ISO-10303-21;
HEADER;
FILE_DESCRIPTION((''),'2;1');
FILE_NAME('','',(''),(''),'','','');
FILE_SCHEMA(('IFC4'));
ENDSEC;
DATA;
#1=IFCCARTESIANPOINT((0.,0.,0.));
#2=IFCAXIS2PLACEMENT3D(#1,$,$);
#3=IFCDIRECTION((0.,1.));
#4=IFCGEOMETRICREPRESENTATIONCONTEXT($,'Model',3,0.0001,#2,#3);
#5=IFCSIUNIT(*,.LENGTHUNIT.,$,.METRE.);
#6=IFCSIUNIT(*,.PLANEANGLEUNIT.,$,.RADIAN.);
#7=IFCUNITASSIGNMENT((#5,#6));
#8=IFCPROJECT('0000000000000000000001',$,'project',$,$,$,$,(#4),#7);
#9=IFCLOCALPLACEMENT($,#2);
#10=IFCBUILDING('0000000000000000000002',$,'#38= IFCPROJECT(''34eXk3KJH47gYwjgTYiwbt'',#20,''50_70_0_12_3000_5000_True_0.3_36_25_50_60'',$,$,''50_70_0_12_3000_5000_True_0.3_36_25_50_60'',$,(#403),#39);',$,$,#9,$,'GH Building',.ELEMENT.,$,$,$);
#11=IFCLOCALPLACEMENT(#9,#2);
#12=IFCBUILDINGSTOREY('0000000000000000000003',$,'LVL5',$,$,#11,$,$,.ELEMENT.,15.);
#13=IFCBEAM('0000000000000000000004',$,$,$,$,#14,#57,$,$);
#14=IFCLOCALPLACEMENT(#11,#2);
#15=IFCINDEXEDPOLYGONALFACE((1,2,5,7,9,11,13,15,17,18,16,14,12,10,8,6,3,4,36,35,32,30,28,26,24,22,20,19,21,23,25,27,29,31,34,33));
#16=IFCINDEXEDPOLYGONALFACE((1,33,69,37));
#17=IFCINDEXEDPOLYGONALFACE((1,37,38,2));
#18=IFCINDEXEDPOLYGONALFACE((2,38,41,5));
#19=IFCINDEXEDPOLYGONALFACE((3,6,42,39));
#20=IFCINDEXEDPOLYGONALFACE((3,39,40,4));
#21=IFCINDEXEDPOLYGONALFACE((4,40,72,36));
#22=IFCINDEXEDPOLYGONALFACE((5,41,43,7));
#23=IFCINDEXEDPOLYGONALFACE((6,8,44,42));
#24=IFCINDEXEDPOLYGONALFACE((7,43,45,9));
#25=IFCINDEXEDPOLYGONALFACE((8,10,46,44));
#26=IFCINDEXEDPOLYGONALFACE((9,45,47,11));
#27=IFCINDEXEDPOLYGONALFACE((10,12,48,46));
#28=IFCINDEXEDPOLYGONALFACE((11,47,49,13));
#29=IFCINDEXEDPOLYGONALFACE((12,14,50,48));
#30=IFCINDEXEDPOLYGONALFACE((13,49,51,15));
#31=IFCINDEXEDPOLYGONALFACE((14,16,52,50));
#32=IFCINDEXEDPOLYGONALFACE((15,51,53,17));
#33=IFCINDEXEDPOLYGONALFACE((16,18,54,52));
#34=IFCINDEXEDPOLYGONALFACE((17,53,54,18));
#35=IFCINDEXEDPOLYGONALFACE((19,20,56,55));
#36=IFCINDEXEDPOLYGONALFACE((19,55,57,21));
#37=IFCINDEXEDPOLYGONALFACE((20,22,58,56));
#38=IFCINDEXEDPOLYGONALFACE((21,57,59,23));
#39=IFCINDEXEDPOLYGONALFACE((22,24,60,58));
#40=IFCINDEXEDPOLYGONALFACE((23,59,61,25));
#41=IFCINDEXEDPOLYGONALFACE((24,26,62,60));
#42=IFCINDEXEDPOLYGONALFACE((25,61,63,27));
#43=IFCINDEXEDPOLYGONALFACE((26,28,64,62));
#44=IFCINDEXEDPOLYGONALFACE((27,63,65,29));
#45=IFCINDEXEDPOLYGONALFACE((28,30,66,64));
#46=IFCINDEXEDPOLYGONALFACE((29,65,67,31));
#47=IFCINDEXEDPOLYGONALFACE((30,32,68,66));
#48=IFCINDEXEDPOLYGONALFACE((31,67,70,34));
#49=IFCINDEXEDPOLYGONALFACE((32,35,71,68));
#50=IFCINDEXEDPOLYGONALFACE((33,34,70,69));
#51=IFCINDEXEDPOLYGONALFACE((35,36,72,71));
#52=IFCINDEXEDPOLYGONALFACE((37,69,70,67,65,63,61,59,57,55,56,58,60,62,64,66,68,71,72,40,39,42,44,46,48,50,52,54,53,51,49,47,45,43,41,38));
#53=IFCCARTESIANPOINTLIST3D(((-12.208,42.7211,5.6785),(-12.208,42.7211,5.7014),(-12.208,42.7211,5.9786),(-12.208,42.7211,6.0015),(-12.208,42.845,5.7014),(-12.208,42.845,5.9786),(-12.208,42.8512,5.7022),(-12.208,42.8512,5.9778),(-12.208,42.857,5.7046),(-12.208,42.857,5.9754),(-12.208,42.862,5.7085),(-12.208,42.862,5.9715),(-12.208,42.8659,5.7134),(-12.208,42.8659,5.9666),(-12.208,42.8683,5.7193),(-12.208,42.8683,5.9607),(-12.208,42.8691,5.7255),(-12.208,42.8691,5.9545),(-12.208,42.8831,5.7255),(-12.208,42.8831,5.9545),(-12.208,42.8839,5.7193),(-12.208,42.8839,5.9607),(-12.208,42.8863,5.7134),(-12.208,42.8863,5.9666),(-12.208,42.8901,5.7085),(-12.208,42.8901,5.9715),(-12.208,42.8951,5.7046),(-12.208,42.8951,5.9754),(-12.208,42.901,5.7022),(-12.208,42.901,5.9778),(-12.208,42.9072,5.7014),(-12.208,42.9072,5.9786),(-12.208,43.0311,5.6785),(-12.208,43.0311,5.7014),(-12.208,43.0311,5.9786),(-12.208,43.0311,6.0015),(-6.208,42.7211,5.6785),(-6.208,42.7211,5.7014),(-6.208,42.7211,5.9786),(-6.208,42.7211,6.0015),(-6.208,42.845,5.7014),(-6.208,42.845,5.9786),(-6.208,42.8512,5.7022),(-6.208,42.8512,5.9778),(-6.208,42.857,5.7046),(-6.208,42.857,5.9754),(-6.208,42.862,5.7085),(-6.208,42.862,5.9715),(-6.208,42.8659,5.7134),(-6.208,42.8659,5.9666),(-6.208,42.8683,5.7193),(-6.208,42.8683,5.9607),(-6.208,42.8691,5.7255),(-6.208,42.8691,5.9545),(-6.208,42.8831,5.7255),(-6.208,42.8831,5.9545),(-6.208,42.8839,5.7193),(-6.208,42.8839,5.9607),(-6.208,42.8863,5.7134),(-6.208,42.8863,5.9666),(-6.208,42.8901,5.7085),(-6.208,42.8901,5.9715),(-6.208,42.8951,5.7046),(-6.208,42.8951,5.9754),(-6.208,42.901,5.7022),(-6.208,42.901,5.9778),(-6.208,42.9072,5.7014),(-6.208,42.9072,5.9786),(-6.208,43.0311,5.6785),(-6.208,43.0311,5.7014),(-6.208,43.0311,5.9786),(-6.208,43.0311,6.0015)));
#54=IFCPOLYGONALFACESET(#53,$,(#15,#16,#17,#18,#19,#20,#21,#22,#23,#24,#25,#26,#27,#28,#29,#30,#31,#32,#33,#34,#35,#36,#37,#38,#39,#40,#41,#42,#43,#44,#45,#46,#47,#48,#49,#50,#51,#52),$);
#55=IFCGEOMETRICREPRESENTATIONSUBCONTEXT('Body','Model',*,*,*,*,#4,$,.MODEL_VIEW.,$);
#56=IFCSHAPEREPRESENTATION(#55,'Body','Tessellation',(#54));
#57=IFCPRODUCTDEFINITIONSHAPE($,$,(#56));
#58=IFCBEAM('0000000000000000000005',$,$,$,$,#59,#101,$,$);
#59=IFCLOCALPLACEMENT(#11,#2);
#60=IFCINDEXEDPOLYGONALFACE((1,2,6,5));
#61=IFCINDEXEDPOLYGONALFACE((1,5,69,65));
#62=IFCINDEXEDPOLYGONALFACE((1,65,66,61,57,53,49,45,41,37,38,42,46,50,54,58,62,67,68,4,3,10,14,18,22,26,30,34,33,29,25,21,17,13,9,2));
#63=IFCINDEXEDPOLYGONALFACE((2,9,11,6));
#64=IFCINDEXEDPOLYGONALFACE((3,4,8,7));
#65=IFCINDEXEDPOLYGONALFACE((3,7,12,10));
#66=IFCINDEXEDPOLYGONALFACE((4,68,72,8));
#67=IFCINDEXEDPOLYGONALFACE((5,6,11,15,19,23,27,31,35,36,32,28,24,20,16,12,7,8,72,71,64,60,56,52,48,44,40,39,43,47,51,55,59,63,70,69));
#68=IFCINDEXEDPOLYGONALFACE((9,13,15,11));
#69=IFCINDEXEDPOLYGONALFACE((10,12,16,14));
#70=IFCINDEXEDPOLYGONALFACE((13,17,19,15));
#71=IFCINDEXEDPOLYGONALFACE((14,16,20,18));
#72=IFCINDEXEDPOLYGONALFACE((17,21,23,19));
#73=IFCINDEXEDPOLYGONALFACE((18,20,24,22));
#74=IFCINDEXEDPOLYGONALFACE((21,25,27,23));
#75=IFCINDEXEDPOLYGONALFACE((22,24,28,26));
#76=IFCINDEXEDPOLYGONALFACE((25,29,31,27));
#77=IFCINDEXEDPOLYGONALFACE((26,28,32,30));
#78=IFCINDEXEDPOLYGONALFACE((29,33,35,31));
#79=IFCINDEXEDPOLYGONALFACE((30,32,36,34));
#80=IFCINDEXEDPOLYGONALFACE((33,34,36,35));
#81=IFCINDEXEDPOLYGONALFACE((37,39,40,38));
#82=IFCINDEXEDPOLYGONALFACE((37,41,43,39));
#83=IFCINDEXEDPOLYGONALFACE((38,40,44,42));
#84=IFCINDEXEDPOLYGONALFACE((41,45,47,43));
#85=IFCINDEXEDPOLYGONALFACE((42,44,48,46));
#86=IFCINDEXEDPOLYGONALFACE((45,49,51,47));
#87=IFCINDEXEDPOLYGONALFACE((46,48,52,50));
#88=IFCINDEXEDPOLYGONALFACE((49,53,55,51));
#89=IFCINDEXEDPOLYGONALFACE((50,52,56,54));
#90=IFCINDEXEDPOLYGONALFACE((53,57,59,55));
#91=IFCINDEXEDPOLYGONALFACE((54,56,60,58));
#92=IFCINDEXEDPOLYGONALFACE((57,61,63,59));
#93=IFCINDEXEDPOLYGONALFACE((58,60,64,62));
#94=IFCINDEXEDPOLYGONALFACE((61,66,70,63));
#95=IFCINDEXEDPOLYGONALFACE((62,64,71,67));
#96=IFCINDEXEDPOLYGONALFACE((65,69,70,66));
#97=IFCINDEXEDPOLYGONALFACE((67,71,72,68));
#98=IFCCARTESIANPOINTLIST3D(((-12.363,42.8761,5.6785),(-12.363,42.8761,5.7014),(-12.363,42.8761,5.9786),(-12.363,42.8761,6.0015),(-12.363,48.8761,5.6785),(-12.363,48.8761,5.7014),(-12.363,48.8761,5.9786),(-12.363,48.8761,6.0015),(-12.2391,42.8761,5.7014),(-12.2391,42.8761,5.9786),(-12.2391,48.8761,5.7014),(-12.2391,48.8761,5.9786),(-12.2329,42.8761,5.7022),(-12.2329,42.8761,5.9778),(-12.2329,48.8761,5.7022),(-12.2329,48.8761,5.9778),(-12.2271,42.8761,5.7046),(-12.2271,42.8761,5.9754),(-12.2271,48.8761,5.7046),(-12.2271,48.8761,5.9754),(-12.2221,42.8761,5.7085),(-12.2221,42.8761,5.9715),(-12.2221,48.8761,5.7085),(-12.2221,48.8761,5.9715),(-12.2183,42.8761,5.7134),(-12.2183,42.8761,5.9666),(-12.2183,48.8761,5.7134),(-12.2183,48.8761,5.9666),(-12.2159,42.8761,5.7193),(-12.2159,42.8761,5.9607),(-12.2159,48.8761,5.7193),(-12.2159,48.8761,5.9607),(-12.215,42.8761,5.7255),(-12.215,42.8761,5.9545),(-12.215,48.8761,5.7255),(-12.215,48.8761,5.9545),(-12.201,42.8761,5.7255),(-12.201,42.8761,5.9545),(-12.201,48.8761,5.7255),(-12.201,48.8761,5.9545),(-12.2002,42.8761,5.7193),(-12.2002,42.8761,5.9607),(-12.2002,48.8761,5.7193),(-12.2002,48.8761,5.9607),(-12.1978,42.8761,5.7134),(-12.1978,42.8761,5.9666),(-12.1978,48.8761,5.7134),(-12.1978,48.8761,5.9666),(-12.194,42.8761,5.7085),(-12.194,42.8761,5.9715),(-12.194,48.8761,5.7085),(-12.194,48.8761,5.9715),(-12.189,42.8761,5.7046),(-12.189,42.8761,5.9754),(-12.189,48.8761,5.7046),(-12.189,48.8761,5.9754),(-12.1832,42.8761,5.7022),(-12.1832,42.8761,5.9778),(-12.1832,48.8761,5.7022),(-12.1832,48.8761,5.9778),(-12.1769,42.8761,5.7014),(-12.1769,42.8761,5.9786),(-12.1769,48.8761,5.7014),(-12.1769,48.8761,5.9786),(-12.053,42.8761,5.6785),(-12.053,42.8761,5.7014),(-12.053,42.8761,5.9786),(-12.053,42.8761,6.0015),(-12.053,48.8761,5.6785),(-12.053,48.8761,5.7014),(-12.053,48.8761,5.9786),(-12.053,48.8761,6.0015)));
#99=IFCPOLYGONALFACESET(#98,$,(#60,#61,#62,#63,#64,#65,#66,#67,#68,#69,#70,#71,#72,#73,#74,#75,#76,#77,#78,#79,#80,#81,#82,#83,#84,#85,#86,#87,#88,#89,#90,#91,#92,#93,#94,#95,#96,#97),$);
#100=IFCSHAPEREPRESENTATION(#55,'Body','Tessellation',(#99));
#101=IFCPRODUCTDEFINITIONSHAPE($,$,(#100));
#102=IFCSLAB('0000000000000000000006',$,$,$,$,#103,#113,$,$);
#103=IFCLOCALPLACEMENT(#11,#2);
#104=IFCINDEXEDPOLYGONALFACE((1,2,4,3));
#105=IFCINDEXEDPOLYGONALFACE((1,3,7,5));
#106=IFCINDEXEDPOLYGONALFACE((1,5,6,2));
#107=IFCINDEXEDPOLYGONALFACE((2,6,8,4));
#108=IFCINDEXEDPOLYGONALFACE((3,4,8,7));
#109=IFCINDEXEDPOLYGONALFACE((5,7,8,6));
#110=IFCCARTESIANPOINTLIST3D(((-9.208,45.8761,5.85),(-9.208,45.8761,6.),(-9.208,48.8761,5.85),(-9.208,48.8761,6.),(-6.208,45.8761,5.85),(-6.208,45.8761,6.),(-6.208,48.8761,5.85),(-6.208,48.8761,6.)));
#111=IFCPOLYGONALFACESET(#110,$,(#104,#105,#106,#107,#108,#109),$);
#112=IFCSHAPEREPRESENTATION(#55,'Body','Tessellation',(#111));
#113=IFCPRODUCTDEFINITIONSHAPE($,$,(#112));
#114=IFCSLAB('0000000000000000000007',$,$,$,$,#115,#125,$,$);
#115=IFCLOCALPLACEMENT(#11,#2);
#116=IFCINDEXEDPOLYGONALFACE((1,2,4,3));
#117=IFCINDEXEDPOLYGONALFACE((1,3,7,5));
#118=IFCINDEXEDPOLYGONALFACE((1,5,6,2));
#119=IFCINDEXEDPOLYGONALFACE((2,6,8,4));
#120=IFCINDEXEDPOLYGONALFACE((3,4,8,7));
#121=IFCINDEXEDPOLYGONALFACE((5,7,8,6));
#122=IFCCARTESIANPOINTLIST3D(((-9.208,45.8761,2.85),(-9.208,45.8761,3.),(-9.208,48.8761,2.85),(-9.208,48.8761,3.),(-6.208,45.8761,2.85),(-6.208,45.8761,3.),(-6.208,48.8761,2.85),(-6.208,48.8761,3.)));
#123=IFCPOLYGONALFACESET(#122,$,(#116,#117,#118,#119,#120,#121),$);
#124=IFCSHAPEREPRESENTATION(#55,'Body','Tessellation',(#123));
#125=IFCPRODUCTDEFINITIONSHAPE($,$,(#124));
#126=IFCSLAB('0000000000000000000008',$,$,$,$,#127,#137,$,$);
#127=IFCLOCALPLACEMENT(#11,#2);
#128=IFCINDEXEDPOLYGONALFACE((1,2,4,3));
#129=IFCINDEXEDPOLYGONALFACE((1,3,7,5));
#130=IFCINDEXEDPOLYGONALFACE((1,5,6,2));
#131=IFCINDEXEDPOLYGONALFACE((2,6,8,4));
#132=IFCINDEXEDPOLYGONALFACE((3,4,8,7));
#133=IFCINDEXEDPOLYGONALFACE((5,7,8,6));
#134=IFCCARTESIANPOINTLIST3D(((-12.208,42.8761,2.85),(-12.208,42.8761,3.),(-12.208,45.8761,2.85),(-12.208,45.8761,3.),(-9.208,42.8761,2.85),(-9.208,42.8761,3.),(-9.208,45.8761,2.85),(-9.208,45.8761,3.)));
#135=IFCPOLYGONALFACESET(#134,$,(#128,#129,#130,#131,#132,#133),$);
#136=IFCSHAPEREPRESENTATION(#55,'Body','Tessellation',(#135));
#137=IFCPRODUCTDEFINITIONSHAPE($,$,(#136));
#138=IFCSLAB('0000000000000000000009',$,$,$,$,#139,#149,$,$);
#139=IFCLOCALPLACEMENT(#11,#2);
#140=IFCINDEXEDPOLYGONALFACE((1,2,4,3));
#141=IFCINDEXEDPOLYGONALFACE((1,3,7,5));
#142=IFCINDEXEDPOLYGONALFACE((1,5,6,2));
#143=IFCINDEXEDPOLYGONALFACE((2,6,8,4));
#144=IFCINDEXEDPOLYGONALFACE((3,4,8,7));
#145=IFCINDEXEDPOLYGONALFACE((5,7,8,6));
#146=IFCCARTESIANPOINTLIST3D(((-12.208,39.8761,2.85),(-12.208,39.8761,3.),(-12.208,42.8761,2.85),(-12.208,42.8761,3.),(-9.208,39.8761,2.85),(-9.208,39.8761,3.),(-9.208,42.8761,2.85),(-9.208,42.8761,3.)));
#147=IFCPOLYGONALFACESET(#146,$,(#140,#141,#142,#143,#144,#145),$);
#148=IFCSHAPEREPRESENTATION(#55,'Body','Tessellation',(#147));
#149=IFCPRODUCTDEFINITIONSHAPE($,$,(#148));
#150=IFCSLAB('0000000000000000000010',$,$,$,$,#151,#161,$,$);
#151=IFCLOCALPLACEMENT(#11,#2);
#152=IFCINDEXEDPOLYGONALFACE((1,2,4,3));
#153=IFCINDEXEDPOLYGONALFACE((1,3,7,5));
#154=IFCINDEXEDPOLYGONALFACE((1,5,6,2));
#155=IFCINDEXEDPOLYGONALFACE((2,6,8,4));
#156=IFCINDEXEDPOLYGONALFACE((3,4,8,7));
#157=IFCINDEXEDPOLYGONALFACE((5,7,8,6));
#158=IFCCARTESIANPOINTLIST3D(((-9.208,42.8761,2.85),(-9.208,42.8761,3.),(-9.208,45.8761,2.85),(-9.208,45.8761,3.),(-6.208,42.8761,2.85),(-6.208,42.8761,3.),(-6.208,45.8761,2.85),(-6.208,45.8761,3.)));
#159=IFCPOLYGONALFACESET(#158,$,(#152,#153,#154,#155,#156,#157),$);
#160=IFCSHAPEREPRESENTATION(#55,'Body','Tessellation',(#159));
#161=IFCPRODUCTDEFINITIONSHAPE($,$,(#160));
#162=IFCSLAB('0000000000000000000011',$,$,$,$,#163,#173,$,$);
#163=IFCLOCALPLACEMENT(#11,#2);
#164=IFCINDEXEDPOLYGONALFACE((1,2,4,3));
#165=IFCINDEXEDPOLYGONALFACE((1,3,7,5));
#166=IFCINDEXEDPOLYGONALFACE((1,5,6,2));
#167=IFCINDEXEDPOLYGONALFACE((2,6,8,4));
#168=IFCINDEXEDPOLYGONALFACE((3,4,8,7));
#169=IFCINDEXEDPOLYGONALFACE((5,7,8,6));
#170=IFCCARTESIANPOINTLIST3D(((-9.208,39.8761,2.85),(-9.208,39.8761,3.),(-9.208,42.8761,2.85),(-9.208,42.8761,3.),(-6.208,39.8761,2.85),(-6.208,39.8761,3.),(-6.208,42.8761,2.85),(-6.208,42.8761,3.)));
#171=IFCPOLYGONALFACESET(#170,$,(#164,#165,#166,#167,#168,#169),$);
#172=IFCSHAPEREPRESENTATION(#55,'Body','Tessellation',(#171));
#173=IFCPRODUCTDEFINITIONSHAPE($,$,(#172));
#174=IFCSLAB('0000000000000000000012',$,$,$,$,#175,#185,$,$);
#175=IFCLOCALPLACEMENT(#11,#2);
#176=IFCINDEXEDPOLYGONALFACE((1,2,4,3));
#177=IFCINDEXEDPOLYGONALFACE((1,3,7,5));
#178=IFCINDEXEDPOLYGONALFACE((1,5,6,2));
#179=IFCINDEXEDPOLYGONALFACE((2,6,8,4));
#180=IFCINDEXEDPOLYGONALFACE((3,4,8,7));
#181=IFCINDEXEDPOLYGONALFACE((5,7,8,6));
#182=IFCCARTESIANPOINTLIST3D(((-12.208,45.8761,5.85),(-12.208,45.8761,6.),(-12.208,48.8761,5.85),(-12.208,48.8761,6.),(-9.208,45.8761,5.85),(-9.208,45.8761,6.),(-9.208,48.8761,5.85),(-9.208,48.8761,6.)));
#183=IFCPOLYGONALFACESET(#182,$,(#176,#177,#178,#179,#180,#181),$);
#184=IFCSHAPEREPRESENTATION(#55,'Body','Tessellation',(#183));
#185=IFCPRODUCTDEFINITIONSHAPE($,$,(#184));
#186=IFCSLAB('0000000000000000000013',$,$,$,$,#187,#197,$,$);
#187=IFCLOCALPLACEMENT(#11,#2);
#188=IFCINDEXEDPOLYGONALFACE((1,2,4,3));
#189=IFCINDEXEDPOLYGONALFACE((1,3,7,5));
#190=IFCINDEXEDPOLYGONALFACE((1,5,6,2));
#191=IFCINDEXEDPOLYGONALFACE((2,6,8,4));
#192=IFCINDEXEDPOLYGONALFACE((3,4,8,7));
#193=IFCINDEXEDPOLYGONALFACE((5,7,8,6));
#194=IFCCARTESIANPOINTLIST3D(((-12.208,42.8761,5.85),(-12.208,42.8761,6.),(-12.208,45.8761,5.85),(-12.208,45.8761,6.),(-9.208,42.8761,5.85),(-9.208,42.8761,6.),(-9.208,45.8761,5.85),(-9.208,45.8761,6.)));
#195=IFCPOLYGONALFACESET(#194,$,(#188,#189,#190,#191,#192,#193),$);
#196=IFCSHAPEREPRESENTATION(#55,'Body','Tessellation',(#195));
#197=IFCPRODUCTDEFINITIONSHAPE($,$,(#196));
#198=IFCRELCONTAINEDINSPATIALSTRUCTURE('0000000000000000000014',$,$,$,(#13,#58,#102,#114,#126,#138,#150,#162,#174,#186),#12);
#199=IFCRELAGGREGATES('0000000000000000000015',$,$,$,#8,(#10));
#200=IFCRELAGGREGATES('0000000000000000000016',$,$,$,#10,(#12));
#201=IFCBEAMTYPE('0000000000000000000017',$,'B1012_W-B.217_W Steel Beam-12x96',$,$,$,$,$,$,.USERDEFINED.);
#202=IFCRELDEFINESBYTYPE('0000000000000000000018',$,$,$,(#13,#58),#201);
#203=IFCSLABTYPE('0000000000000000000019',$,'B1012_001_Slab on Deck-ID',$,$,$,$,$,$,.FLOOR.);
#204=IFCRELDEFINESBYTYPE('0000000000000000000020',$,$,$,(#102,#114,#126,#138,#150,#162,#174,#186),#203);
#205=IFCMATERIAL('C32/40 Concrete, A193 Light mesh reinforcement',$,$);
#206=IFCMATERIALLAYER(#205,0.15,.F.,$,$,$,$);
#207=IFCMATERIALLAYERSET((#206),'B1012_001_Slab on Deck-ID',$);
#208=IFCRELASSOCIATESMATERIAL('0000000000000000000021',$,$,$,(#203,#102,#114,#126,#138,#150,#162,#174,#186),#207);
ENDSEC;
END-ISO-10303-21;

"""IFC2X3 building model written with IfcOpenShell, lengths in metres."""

from ifc_helpers import new_model, si_unit, direction, frame, origin, origin_2d, place, context, subcontext, project, spatial, polyline, i_section, outline, extrude, material, layer, layer_set, layer_usage, type_object, element, save


model = new_model("IFC2X3")

# Units and contexts
model_context = context("Model", 3, precision=0.0001, world=origin(), true_north=direction((0.0, 1.0)))
body_context = subcontext(model_context, "Body", "Model", "MODEL_VIEW")
ifc_project = project(units=[si_unit("LENGTHUNIT", "METRE"), si_unit("PLANEANGLEUNIT", "RADIAN")], contexts=[model_context])

# Building, storey
building_placement = place(None, origin())
building = spatial("IfcBuilding", under=ifc_project, at=building_placement, Name="#38= IFCPROJECT('34eXk3KJH47gYwjgTYiwbt',#20,'50_70_0_12_3000_5000_True_0.3_36_25_50_60',$,$,'50_70_0_12_3000_5000_True_0.3_36_25_50_60',$,(#403),#39);", LongName="GH Building", CompositionType="ELEMENT")
storey_placement = place(building_placement, origin())
storey = spatial("IfcBuildingStorey", under=building, at=storey_placement, Name="LVL5", CompositionType="ELEMENT", Elevation=15.0)

# Beams
beam_type = type_object("IfcBeamType", Name="B1012_W-B.217_W Steel Beam-12x96", PredefinedType="USERDEFINED")
for number, where, z_axis, x_axis in (
    (1, (-12.208, 42.8761, 5.84), (1.0, 0.0, 0.0), (0.0, 1.0, 0.0)),
    (2, (-12.208, 42.8761, 5.84), (0.0, 1.0, 0.0), (-1.0, 0.0, 0.0)),
):
    element("IfcBeam", number, at=place(storey_placement, frame(where, z_axis=z_axis, x_axis=x_axis)), inside=storey, type_object=beam_type, context=body_context, shape_type="SweptSolid", body=[
        extrude(i_section(OverallWidth=0.31, OverallDepth=0.323, WebThickness=0.014, FlangeThickness=0.0229, FilletRadius=0.0241, at=origin_2d()), origin(), (0.0, 0.0, 1.0), 6.0),
    ])

# Slabs
ifc_material_1 = material(Name="C32/40 Concrete, A193 Light mesh reinforcement")
ifc_layer_1 = layer(ifc_material_1, 0.15, ventilated=False)
ifc_layer_set_1 = layer_set([ifc_layer_1], Name="B1012_001_Slab on Deck-ID")
ifc_layer_usage_1 = layer_usage(ifc_layer_set_1, "AXIS3", "NEGATIVE", -0.15)
slab_type_1 = type_object("IfcSlabType", Name="B1012_001_Slab on Deck-ID", PredefinedType="FLOOR", material=ifc_layer_set_1)
slab_1_placement = place(storey_placement, frame((-7.708, 47.3761, 5.85)))
element("IfcSlab", 3, at=slab_1_placement, inside=storey, type_object=slab_type_1, material=ifc_layer_usage_1, context=body_context, shape_type="SweptSolid", body=[
    extrude(outline(polyline([(1.5, -1.5), (-1.5, -1.5), (-1.5, 1.5), (1.5, 1.5), (1.5, -1.5)])), origin(), (0.0, 0.0, 1.0), 0.15),
])
ifc_layer_usage_2 = layer_usage(ifc_layer_set_1, "AXIS3", "NEGATIVE", -0.15)
slab_2_placement = place(storey_placement, frame((-7.708, 47.3761, 2.85), z_axis=(0.0, 0.0, 1.0), x_axis=(0.0, -1.0, 0.0)))
element("IfcSlab", 4, at=slab_2_placement, inside=storey, type_object=slab_type_1, material=ifc_layer_usage_2, context=body_context, shape_type="SweptSolid", body=[
    extrude(outline(polyline([(-1.5, -1.5), (1.5, -1.5), (1.5, 1.5), (-1.5, 1.5), (-1.5, -1.5)])), origin(), (0.0, 0.0, 1.0), 0.15),
])
ifc_layer_usage_3 = layer_usage(ifc_layer_set_1, "AXIS3", "NEGATIVE", -0.15)
slab_3_placement = place(storey_placement, frame((-10.708, 44.3761, 2.85), z_axis=(0.0, 0.0, 1.0), x_axis=(0.0, -1.0, 0.0)))
element("IfcSlab", 5, at=slab_3_placement, inside=storey, type_object=slab_type_1, material=ifc_layer_usage_3, context=body_context, shape_type="SweptSolid", body=[
    extrude(outline(polyline([(-1.5, -1.5), (1.5, -1.5), (1.5, 1.5), (-1.5, 1.5), (-1.5, -1.5)])), origin(), (0.0, 0.0, 1.0), 0.15),
])
ifc_layer_usage_4 = layer_usage(ifc_layer_set_1, "AXIS3", "NEGATIVE", -0.15)
slab_4_placement = place(storey_placement, frame((-10.708, 41.3761, 2.85), z_axis=(0.0, 0.0, 1.0), x_axis=(0.0, -1.0, 0.0)))
element("IfcSlab", 6, at=slab_4_placement, inside=storey, type_object=slab_type_1, material=ifc_layer_usage_4, context=body_context, shape_type="SweptSolid", body=[
    extrude(outline(polyline([(-1.5, -1.5), (1.5, -1.5), (1.5, 1.5), (-1.5, 1.5), (-1.5, -1.5)])), origin(), (0.0, 0.0, 1.0), 0.15),
])
ifc_layer_usage_5 = layer_usage(ifc_layer_set_1, "AXIS3", "NEGATIVE", -0.15)
slab_5_placement = place(storey_placement, frame((-7.708, 44.3761, 2.85), z_axis=(0.0, 0.0, 1.0), x_axis=(0.0, -1.0, 0.0)))
element("IfcSlab", 7, at=slab_5_placement, inside=storey, type_object=slab_type_1, material=ifc_layer_usage_5, context=body_context, shape_type="SweptSolid", body=[
    extrude(outline(polyline([(-1.5, -1.5), (1.5, -1.5), (1.5, 1.5), (-1.5, 1.5), (-1.5, -1.5)])), origin(), (0.0, 0.0, 1.0), 0.15),
])
ifc_layer_usage_6 = layer_usage(ifc_layer_set_1, "AXIS3", "NEGATIVE", -0.15)
slab_6_placement = place(storey_placement, frame((-7.708, 41.3761, 2.85), z_axis=(0.0, 0.0, 1.0), x_axis=(0.0, -1.0, 0.0)))
element("IfcSlab", 8, at=slab_6_placement, inside=storey, type_object=slab_type_1, material=ifc_layer_usage_6, context=body_context, shape_type="SweptSolid", body=[
    extrude(outline(polyline([(-1.5, -1.5), (1.5, -1.5), (1.5, 1.5), (-1.5, 1.5), (-1.5, -1.5)])), origin(), (0.0, 0.0, 1.0), 0.15),
])
ifc_layer_usage_7 = layer_usage(ifc_layer_set_1, "AXIS3", "NEGATIVE", -0.15)
slab_7_placement = place(storey_placement, frame((-10.708, 47.3761, 5.85)))
element("IfcSlab", 9, at=slab_7_placement, inside=storey, type_object=slab_type_1, material=ifc_layer_usage_7, context=body_context, shape_type="SweptSolid", body=[
    extrude(outline(polyline([(1.5, 1.5), (1.5, -1.5), (-1.5, -1.5), (-1.5, 1.5), (1.5, 1.5)])), origin(), (0.0, 0.0, 1.0), 0.15),
])
ifc_layer_usage_8 = layer_usage(ifc_layer_set_1, "AXIS3", "NEGATIVE", -0.15)
slab_8_placement = place(storey_placement, frame((-10.708, 44.3761, 5.85)))
element("IfcSlab", 10, at=slab_8_placement, inside=storey, type_object=slab_type_1, material=ifc_layer_usage_8, context=body_context, shape_type="SweptSolid", body=[
    extrude(outline(polyline([(1.5, 1.5), (1.5, -1.5), (-1.5, -1.5), (-1.5, 1.5), (1.5, 1.5)])), origin(), (0.0, 0.0, 1.0), 0.15),
])

save(model, "model.ifc")
